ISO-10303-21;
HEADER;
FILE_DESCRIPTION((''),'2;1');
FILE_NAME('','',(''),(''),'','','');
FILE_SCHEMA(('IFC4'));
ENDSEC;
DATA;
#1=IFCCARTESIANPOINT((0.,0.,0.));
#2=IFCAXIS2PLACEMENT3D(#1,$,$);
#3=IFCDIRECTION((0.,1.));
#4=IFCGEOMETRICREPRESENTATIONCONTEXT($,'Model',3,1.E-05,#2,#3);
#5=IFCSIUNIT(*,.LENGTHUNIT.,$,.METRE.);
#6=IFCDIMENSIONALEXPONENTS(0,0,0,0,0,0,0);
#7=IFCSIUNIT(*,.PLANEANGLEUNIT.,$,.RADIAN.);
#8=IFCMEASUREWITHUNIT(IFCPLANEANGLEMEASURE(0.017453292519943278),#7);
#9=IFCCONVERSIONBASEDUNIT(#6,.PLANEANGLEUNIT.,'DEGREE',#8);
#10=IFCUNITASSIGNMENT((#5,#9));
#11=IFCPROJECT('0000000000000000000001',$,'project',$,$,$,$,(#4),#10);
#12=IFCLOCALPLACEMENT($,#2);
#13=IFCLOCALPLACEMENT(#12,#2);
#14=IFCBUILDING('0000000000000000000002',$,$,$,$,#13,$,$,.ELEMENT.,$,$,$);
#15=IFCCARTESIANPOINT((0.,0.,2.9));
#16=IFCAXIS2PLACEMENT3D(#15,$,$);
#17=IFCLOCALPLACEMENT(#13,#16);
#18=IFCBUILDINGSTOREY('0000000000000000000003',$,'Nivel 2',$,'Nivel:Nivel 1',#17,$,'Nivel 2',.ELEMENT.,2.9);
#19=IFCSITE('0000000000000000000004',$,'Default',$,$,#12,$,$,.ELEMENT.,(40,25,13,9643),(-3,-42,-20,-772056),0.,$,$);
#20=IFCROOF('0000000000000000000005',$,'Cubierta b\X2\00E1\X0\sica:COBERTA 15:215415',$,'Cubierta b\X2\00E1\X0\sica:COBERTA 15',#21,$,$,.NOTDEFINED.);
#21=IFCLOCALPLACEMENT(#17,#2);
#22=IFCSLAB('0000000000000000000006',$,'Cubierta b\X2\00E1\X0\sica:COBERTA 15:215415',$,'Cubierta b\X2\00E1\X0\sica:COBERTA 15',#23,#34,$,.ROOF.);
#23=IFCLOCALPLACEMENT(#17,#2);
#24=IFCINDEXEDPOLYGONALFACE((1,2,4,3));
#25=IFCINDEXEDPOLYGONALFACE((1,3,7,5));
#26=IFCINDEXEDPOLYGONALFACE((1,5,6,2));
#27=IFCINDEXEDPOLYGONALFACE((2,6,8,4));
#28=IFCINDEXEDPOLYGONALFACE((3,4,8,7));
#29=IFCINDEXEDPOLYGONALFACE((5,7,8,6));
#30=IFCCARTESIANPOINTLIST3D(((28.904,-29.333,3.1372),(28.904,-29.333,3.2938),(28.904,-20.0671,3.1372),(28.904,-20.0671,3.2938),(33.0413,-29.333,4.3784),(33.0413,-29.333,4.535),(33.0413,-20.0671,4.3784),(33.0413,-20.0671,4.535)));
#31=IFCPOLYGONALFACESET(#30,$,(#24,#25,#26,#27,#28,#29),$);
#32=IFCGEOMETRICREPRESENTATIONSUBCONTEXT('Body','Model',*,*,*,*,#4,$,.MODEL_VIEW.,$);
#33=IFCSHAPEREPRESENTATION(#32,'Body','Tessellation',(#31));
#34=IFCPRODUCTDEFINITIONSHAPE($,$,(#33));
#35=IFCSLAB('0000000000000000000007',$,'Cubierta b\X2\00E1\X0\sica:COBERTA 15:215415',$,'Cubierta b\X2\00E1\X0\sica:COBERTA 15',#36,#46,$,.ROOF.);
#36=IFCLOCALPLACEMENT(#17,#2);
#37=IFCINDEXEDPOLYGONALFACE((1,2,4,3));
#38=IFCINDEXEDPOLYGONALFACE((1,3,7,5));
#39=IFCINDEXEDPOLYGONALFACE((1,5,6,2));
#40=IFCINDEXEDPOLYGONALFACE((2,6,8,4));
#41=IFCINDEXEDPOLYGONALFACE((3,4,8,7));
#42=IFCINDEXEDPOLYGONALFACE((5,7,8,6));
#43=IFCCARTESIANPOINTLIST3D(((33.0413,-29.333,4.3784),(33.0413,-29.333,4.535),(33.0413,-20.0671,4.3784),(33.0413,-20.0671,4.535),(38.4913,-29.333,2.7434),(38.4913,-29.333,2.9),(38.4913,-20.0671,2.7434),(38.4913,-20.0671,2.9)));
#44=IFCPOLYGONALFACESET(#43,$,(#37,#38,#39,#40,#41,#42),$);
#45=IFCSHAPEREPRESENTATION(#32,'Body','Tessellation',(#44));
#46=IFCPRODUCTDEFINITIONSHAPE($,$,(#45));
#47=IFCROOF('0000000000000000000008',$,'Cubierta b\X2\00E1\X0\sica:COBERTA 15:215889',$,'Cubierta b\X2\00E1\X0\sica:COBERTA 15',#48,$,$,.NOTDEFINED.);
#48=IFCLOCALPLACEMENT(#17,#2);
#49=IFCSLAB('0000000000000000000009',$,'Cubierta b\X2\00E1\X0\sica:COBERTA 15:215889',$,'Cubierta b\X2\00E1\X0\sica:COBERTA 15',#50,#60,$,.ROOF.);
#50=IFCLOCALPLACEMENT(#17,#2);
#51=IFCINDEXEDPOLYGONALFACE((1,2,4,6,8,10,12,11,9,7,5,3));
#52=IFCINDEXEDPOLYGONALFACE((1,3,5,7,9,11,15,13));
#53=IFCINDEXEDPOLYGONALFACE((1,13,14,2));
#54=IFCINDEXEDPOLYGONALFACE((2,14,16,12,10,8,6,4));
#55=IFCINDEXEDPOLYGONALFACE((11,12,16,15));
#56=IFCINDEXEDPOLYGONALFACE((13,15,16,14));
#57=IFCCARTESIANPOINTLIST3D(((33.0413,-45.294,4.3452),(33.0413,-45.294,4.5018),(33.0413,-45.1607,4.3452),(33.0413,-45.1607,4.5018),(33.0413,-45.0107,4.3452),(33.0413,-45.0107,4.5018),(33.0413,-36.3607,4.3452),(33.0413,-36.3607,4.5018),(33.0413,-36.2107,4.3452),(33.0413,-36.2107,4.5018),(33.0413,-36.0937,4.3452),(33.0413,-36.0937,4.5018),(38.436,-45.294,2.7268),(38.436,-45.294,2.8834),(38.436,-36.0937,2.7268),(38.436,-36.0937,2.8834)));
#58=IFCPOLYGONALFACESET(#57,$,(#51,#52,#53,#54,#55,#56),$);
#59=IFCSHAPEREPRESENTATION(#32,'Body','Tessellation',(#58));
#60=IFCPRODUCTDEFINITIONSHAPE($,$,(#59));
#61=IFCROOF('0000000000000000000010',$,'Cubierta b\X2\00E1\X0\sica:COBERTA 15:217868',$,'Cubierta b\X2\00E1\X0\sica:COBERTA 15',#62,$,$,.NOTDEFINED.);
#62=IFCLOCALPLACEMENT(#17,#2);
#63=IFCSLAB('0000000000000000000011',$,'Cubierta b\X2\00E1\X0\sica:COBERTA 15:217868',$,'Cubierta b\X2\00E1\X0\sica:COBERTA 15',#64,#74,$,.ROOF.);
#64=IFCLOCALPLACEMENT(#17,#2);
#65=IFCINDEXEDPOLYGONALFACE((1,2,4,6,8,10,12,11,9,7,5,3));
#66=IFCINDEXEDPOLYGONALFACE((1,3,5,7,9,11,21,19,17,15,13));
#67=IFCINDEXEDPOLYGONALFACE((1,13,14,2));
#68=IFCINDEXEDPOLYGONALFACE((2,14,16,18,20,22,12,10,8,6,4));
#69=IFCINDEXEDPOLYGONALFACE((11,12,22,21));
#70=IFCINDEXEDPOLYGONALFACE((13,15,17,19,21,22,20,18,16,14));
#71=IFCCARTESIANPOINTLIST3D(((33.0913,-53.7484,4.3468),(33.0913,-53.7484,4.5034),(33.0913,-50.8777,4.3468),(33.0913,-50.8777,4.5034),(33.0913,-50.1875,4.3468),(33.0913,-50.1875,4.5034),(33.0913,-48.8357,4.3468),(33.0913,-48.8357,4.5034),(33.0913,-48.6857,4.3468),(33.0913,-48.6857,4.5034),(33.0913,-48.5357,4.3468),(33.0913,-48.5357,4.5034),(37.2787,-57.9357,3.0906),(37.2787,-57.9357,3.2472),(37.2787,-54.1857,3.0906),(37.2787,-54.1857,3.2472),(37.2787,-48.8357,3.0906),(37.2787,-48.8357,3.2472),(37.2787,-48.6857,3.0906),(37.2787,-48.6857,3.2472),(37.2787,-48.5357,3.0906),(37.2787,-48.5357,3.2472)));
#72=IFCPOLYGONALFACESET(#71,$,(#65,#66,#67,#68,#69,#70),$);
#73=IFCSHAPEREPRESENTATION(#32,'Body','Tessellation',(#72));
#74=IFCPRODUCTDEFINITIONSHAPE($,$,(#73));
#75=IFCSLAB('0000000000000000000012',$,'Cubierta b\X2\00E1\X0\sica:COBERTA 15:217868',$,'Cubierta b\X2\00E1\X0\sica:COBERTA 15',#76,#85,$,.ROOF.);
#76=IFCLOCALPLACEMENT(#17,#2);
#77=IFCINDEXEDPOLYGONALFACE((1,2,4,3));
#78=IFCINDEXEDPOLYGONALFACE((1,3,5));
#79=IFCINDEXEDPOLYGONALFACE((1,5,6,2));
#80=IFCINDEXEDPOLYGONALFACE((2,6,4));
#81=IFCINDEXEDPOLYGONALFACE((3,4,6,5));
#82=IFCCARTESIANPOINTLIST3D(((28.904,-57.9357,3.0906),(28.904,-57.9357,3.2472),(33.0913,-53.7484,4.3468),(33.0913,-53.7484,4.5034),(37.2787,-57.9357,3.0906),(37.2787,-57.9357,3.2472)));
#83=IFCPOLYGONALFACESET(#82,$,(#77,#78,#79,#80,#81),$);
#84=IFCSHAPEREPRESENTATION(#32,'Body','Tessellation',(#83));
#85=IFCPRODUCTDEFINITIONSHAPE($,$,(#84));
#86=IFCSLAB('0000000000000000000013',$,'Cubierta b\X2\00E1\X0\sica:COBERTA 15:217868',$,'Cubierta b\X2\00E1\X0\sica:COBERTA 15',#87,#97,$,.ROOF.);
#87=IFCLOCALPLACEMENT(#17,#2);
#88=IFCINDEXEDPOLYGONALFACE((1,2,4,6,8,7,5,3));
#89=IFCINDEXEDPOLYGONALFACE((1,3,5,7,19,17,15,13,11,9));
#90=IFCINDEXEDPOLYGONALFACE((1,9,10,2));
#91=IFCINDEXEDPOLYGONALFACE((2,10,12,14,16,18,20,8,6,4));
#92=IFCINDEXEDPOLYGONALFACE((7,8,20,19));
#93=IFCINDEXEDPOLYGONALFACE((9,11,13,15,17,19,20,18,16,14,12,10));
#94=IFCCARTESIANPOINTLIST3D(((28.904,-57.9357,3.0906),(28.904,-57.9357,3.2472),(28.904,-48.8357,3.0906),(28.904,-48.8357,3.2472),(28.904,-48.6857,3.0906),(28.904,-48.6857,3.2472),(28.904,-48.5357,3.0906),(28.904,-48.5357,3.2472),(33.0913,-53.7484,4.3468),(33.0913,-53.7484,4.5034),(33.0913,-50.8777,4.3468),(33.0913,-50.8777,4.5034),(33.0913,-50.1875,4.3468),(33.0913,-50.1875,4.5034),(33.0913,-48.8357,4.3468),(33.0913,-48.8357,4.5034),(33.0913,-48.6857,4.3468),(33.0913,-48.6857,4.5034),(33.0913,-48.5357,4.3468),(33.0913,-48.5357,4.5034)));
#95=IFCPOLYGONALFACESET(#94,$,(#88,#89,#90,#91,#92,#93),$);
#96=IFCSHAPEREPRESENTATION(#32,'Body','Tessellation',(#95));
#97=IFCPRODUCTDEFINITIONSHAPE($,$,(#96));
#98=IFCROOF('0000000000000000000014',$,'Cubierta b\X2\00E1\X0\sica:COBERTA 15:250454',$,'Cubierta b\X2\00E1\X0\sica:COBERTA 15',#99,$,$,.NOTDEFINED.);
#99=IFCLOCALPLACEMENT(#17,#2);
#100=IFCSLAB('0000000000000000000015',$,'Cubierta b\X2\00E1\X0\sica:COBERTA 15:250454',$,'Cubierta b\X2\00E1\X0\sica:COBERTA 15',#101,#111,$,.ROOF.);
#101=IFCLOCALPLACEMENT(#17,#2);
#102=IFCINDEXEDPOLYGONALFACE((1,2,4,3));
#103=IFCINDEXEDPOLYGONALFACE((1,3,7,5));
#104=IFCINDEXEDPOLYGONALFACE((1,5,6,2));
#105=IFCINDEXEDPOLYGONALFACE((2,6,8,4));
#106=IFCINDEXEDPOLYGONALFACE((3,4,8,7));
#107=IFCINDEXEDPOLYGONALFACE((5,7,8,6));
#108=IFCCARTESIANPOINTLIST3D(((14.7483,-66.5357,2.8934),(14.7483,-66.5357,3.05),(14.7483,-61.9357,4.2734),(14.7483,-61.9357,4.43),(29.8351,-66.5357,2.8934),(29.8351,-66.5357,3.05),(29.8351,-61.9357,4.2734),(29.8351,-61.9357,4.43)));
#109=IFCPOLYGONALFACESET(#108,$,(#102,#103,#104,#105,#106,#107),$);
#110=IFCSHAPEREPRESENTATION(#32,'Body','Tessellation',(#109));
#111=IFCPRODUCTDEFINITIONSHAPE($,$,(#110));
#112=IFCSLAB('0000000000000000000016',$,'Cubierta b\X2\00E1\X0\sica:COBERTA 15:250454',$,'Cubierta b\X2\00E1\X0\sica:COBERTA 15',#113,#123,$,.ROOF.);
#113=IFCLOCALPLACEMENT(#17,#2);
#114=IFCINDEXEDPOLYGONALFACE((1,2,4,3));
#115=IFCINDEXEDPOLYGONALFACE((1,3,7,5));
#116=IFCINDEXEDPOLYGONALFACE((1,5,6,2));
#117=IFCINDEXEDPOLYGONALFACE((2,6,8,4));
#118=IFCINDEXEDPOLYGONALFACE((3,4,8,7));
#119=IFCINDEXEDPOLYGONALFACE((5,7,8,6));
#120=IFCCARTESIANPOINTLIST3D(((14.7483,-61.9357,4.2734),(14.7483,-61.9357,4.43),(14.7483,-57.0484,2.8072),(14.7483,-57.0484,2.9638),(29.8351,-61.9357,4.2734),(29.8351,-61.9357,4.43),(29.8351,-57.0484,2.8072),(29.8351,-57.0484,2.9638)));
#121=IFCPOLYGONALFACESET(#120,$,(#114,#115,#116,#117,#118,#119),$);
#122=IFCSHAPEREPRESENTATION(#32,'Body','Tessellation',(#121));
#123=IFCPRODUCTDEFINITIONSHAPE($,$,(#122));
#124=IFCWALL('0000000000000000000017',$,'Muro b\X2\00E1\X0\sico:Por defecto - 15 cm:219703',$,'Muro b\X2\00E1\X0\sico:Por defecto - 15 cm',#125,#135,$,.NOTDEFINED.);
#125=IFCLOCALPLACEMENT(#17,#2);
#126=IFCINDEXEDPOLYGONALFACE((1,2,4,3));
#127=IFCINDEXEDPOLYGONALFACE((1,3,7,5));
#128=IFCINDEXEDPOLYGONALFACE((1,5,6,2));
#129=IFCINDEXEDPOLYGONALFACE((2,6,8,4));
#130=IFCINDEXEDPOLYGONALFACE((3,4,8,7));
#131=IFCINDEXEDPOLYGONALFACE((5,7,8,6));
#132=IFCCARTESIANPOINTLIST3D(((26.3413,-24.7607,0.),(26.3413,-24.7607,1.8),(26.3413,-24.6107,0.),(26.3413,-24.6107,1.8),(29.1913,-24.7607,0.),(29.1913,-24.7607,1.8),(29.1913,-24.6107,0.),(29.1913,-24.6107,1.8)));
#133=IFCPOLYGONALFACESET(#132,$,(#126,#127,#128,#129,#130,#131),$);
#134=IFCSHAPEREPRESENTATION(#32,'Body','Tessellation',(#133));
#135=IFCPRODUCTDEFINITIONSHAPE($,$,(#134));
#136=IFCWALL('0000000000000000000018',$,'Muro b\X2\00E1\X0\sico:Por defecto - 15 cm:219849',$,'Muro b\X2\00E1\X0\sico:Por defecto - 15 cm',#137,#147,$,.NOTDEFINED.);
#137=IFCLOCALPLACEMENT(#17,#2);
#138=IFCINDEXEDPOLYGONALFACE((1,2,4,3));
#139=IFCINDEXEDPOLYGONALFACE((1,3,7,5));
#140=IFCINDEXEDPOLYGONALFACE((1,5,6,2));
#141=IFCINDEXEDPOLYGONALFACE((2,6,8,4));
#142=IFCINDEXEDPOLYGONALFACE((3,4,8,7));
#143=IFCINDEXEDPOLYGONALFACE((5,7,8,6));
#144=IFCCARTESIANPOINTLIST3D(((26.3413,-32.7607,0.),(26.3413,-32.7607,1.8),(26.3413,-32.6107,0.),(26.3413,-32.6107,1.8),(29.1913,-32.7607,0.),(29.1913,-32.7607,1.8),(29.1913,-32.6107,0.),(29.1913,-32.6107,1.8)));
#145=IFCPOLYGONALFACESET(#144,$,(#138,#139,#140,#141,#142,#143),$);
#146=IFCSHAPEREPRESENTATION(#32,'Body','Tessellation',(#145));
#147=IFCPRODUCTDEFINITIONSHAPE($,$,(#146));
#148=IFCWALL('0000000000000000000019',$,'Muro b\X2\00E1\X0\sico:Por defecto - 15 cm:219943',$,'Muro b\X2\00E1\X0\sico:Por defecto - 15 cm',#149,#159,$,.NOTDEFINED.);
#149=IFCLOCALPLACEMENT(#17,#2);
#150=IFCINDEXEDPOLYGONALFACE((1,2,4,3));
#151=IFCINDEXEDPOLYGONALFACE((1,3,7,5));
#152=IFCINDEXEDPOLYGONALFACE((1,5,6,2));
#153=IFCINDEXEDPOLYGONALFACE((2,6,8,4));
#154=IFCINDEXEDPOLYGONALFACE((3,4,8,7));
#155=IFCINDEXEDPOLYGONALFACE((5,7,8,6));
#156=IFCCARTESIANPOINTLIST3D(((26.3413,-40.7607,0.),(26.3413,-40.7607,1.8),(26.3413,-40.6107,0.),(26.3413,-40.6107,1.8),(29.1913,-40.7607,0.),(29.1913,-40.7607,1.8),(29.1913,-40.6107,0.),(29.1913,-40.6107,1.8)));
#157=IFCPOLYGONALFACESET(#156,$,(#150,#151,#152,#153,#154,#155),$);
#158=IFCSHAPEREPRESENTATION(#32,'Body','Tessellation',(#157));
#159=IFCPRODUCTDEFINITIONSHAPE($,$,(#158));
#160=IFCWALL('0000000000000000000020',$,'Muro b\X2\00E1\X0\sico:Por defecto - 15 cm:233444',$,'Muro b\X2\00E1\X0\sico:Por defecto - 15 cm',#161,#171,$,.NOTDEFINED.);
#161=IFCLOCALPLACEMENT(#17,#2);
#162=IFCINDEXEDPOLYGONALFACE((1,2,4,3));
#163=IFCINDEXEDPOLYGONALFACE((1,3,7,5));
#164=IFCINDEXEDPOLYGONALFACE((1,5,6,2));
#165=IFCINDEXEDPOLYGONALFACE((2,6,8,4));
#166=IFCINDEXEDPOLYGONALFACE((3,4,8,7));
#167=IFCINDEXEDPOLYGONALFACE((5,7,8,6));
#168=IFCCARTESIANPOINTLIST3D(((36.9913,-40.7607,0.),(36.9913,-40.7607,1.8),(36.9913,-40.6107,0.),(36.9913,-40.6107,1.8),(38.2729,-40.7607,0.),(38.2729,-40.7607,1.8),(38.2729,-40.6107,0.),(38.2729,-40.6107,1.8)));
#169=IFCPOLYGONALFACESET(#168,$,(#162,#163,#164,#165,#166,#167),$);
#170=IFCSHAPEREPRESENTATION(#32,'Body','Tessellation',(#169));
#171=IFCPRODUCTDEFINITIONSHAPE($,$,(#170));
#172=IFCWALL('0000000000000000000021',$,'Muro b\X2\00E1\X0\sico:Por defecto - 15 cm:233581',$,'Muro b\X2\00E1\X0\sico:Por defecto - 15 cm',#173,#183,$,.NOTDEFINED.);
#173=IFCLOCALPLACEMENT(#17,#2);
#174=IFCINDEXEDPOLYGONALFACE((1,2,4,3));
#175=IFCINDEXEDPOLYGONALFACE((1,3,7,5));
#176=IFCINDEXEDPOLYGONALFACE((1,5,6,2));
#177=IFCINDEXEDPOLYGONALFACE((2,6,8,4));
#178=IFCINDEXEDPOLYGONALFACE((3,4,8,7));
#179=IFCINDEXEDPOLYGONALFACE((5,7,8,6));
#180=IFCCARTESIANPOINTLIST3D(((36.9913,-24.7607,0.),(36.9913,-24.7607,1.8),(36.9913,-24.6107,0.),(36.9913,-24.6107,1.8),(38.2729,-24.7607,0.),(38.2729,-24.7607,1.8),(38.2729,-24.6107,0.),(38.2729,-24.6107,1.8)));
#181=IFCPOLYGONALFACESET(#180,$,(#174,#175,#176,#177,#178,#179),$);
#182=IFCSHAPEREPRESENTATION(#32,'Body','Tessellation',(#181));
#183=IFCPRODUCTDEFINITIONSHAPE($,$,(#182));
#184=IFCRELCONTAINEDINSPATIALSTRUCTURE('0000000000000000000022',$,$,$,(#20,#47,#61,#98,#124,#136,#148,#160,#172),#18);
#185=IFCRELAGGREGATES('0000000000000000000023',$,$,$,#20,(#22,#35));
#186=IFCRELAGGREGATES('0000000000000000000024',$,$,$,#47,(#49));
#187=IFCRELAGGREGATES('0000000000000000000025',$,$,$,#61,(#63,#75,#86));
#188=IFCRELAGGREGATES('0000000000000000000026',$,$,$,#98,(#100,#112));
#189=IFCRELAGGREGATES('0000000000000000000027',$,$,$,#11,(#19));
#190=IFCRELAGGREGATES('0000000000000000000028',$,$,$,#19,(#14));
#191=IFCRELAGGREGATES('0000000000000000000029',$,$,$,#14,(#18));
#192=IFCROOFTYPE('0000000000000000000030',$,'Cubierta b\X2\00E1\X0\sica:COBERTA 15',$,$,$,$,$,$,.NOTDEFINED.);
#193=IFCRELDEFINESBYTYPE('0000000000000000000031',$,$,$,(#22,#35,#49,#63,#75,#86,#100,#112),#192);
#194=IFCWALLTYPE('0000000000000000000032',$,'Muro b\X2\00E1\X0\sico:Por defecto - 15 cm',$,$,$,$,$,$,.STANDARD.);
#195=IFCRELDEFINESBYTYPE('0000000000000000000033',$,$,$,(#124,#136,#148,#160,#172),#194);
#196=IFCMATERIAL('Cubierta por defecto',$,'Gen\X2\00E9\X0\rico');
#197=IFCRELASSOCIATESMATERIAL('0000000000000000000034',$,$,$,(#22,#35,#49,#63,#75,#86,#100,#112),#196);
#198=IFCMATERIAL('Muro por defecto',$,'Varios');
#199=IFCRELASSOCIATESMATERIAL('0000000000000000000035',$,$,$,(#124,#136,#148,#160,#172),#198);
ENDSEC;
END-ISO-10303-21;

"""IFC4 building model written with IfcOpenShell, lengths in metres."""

from ifc_helpers import new_model, entity, si_unit, converted_unit, direction, frame, origin, place, context, subcontext, project, spatial, indexed_curve, outline, extrude, material, type_object, element, aggregate, save


model = new_model("IFC4")

# Units and contexts
model_context = context("Model", 3, precision=1e-05, world=origin(), true_north=direction((0.0, 1.0)))
body_context = subcontext(model_context, "Body", "Model", "MODEL_VIEW")
ifc_project = project(units=[si_unit("LENGTHUNIT", "METRE"), converted_unit("PLANEANGLEUNIT", "DEGREE", entity("IfcPlaneAngleMeasure", 0.017453292519943278), si_unit("PLANEANGLEUNIT", "RADIAN"), dimensions=[0, 0, 0, 0, 0, 0, 0])], contexts=[model_context])

# Site, building, storey
site_placement = place(None, origin())
site = spatial("IfcSite", under=ifc_project, at=site_placement, Name="Default", CompositionType="ELEMENT", RefLatitude=(40, 25, 13, 9643), RefLongitude=(-3, -42, -20, -772056), RefElevation=0.0)
building_placement = place(site_placement, origin())
building = spatial("IfcBuilding", under=site, at=building_placement, CompositionType="ELEMENT")
storey_placement = place(building_placement, frame((0.0, 0.0, 2.9)))
storey = spatial("IfcBuildingStorey", under=building, at=storey_placement, Name="Nivel 2", ObjectType="Nivel:Nivel 1", LongName="Nivel 2", CompositionType="ELEMENT", Elevation=2.9)

# Roofs, slabs
roof_1_placement = place(storey_placement, frame((28.904, -29.333, 2.7434)))
roof_1 = element("IfcRoof", 1, at=roof_1_placement, inside=storey, Name="Cubierta básica:COBERTA 15:215415", ObjectType="Cubierta básica:COBERTA 15", PredefinedType="NOTDEFINED")
ifc_material_1 = material(Name="Cubierta por defecto", Category="Genérico")
roof_type = type_object("IfcRoofType", Name="Cubierta básica:COBERTA 15", PredefinedType="NOTDEFINED")
slab_1_placement = place(roof_1_placement, origin())
slab_1 = element("IfcSlab", 2, at=slab_1_placement, type_object=roof_type, material=ifc_material_1, Name="Cubierta básica:COBERTA 15:215415", ObjectType="Cubierta básica:COBERTA 15", PredefinedType="ROOF", context=body_context, shape_type="SweptSolid", body=[
    extrude(outline(indexed_curve([(2.1598, -4.633), (2.1598, 4.633), (-2.1598, 4.633), (-2.1598, -4.633), (2.1598, -4.633)], self_intersect=False)), frame((2.0687, 4.633, 1.0144), z_axis=(-0.287348, 0.0, 0.957826), x_axis=(0.957826, 0.0, 0.287348)), (0.287348, 0.0, 0.957826), 0.1566),
])
slab_2_placement = place(roof_1_placement, origin())
slab_2 = element("IfcSlab", 3, at=slab_2_placement, type_object=roof_type, material=ifc_material_1, Name="Cubierta básica:COBERTA 15:215415", ObjectType="Cubierta básica:COBERTA 15", PredefinedType="ROOF", context=body_context, shape_type="SweptSolid", body=[
    extrude(outline(indexed_curve([(2.845, -4.633), (2.845, 4.633), (-2.845, 4.633), (-2.845, -4.633), (2.845, -4.633)], self_intersect=False)), frame((6.8623, 4.633, 0.8175), z_axis=(0.287348, 0.0, 0.957826), x_axis=(0.957826, 0.0, -0.287348)), (-0.287348, 0.0, 0.957826), 0.1566),
])
aggregate(roof_1, [slab_1, slab_2])
roof_2_placement = place(storey_placement, frame((28.904, -45.294, 2.7268)))
roof_2 = element("IfcRoof", 4, at=roof_2_placement, inside=storey, Name="Cubierta básica:COBERTA 15:215889", ObjectType="Cubierta básica:COBERTA 15", PredefinedType="NOTDEFINED")
slab_3_placement = place(roof_2_placement, origin())
slab_3 = element("IfcSlab", 5, at=slab_3_placement, type_object=roof_type, material=ifc_material_1, Name="Cubierta básica:COBERTA 15:215889", ObjectType="Cubierta básica:COBERTA 15", PredefinedType="ROOF", context=body_context, shape_type="SweptSolid", body=[
    extrude(outline(indexed_curve([(2.8161, -4.6001), (2.8161, 4.6001), (-2.8161, 4.6001), (-2.8161, 4.4831), (-2.8161, 4.3331), (-2.8161, -4.3169), (-2.8161, -4.4669), (-2.8161, -4.6001), (2.8161, -4.6001)], self_intersect=False)), frame((6.8347, 4.6001, 0.8092), z_axis=(0.287348, 0.0, 0.957826), x_axis=(0.957826, 0.0, -0.287348)), (-0.287348, 0.0, 0.957826), 0.1566),
])
aggregate(roof_2, [slab_3])
roof_3_placement = place(storey_placement, frame((28.904, -57.9357, 3.0906)))
roof_3 = element("IfcRoof", 6, at=roof_3_placement, inside=storey, Name="Cubierta básica:COBERTA 15:217868", ObjectType="Cubierta básica:COBERTA 15", PredefinedType="NOTDEFINED")
slab_4_placement = place(roof_3_placement, origin())
slab_4 = element("IfcSlab", 7, at=slab_4_placement, type_object=roof_type, material=ifc_material_1, Name="Cubierta básica:COBERTA 15:217868", ObjectType="Cubierta básica:COBERTA 15", PredefinedType="ROOF", context=body_context, shape_type="SweptSolid", body=[
    extrude(outline(indexed_curve([(-2.1859, 4.7), (-2.1859, 4.55), (-2.1859, 4.4), (-2.1859, 3.0482), (-2.1859, 2.358), (-2.1859, -0.5127), (2.1859, -4.7), (2.1859, -0.95), (2.1859, 4.4), (2.1859, 4.55), (2.1859, 4.7), (-2.1859, 4.7)], self_intersect=False)), frame((6.281, 4.7, 0.6281), z_axis=(0.287348, 0.0, 0.957826), x_axis=(0.957826, 0.0, -0.287348)), (-0.287348, 0.0, 0.957826), 0.1566),
])
slab_5_placement = place(roof_3_placement, origin())
slab_5 = element("IfcSlab", 8, at=slab_5_placement, type_object=roof_type, material=ifc_material_1, Name="Cubierta básica:COBERTA 15:217868", ObjectType="Cubierta básica:COBERTA 15", PredefinedType="ROOF", context=body_context, shape_type="SweptSolid", body=[
    extrude(outline(indexed_curve([(-4.1873, -2.1859), (4.1873, -2.1859), (0.0, 2.1859), (-4.1873, -2.1859)], self_intersect=False)), frame((4.1873, 2.0937, 0.6281), z_axis=(0.0, -0.287348, 0.957826), x_axis=(1.0, 0.0, 0.0)), (0.0, 0.287348, 0.957826), 0.1566),
])
slab_6_placement = place(roof_3_placement, origin())
slab_6 = element("IfcSlab", 9, at=slab_6_placement, type_object=roof_type, material=ifc_material_1, Name="Cubierta básica:COBERTA 15:217868", ObjectType="Cubierta básica:COBERTA 15", PredefinedType="ROOF", context=body_context, shape_type="SweptSolid", body=[
    extrude(outline(indexed_curve([(-2.1859, 4.7), (-2.1859, 4.55), (-2.1859, 4.4), (-2.1859, -4.7), (2.1859, -0.5127), (2.1859, 2.358), (2.1859, 3.0482), (2.1859, 4.4), (2.1859, 4.55), (2.1859, 4.7), (-2.1859, 4.7)], self_intersect=False)), frame((2.0937, 4.7, 0.6281), z_axis=(-0.287348, 0.0, 0.957826), x_axis=(0.957826, 0.0, 0.287348)), (0.287348, 0.0, 0.957826), 0.1566),
])
aggregate(roof_3, [slab_4, slab_5, slab_6])
roof_4_placement = place(storey_placement, frame((14.7483, -66.5357, 2.8072)))
roof_4 = element("IfcRoof", 10, at=roof_4_placement, inside=storey, Name="Cubierta básica:COBERTA 15:250454", ObjectType="Cubierta básica:COBERTA 15", PredefinedType="NOTDEFINED")
slab_7_placement = place(roof_4_placement, origin())
slab_7 = element("IfcSlab", 11, at=slab_7_placement, type_object=roof_type, material=ifc_material_1, Name="Cubierta básica:COBERTA 15:250454", ObjectType="Cubierta básica:COBERTA 15", PredefinedType="ROOF", context=body_context, shape_type="SweptSolid", body=[
    extrude(outline(indexed_curve([(-7.5434, -2.4013), (7.5434, -2.4013), (7.5434, 2.4013), (-7.5434, 2.4013), (-7.5434, -2.4013)], self_intersect=False)), frame((7.5434, 2.3, 0.7762), z_axis=(0.0, -0.287348, 0.957826), x_axis=(1.0, 0.0, 0.0)), (0.0, 0.287348, 0.957826), 0.1566),
])
slab_8_placement = place(roof_4_placement, origin())
slab_8 = element("IfcSlab", 12, at=slab_8_placement, type_object=roof_type, material=ifc_material_1, Name="Cubierta básica:COBERTA 15:250454", ObjectType="Cubierta básica:COBERTA 15", PredefinedType="ROOF", context=body_context, shape_type="SweptSolid", body=[
    extrude(outline(indexed_curve([(-7.5434, -2.5513), (7.5434, -2.5513), (7.5434, 2.5513), (-7.5434, 2.5513), (-7.5434, -2.5513)], self_intersect=False)), frame((7.5434, 7.0437, 0.7331), z_axis=(0.0, 0.287348, 0.957826), x_axis=(1.0, 0.0, 0.0)), (0.0, -0.287348, 0.957826), 0.1566),
])
aggregate(roof_4, [slab_7, slab_8])

# Walls
ifc_material_2 = material(Name="Muro por defecto", Category="Varios")
wall_type_1 = type_object("IfcWallType", Name="Muro básico:Por defecto - 15 cm", PredefinedType="STANDARD")
wall_1_placement = place(storey_placement, frame((26.3413, -24.6857, 0.0)))
element("IfcWall", 13, at=wall_1_placement, inside=storey, type_object=wall_type_1, material=ifc_material_2, Name="Muro básico:Por defecto - 15 cm:219703", ObjectType="Muro básico:Por defecto - 15 cm", PredefinedType="NOTDEFINED", context=body_context, shape_type="SweptSolid", body=[
    extrude(outline(indexed_curve([(2.85, 0.075), (0.0, 0.075), (0.0, -0.075), (2.85, -0.075), (2.85, 0.075)], self_intersect=False)), origin(), (0.0, 0.0, 1.0), 1.8),
])
wall_2_placement = place(storey_placement, frame((26.3413, -32.6857, 0.0)))
element("IfcWall", 14, at=wall_2_placement, inside=storey, type_object=wall_type_1, material=ifc_material_2, Name="Muro básico:Por defecto - 15 cm:219849", ObjectType="Muro básico:Por defecto - 15 cm", PredefinedType="NOTDEFINED", context=body_context, shape_type="SweptSolid", body=[
    extrude(outline(indexed_curve([(2.85, 0.075), (0.0, 0.075), (0.0, -0.075), (2.85, -0.075), (2.85, 0.075)], self_intersect=False)), origin(), (0.0, 0.0, 1.0), 1.8),
])
wall_3_placement = place(storey_placement, frame((26.3413, -40.6857, 0.0)))
element("IfcWall", 15, at=wall_3_placement, inside=storey, type_object=wall_type_1, material=ifc_material_2, Name="Muro básico:Por defecto - 15 cm:219943", ObjectType="Muro básico:Por defecto - 15 cm", PredefinedType="NOTDEFINED", context=body_context, shape_type="SweptSolid", body=[
    extrude(outline(indexed_curve([(2.85, 0.075), (0.0, 0.075), (0.0, -0.075), (2.85, -0.075), (2.85, 0.075)], self_intersect=False)), origin(), (0.0, 0.0, 1.0), 1.8),
])
for number, where, name in (
    (16, (36.9913, -40.6857, 0.0), "Muro básico:Por defecto - 15 cm:233444"),
    (17, (36.9913, -24.6857, 0.0), "Muro básico:Por defecto - 15 cm:233581"),
):
    element("IfcWall", number, at=place(storey_placement, frame(where)), inside=storey, type_object=wall_type_1, material=ifc_material_2, Name=name, ObjectType="Muro básico:Por defecto - 15 cm", PredefinedType="NOTDEFINED", context=body_context, shape_type="SweptSolid", body=[
        extrude(outline(indexed_curve([(1.2816, 0.075), (0.0, 0.075), (0.0, -0.075), (1.2816, -0.075), (1.2816, 0.075)], self_intersect=False)), origin(), (0.0, 0.0, 1.0), 1.8),
    ])

save(model, "model.ifc")
